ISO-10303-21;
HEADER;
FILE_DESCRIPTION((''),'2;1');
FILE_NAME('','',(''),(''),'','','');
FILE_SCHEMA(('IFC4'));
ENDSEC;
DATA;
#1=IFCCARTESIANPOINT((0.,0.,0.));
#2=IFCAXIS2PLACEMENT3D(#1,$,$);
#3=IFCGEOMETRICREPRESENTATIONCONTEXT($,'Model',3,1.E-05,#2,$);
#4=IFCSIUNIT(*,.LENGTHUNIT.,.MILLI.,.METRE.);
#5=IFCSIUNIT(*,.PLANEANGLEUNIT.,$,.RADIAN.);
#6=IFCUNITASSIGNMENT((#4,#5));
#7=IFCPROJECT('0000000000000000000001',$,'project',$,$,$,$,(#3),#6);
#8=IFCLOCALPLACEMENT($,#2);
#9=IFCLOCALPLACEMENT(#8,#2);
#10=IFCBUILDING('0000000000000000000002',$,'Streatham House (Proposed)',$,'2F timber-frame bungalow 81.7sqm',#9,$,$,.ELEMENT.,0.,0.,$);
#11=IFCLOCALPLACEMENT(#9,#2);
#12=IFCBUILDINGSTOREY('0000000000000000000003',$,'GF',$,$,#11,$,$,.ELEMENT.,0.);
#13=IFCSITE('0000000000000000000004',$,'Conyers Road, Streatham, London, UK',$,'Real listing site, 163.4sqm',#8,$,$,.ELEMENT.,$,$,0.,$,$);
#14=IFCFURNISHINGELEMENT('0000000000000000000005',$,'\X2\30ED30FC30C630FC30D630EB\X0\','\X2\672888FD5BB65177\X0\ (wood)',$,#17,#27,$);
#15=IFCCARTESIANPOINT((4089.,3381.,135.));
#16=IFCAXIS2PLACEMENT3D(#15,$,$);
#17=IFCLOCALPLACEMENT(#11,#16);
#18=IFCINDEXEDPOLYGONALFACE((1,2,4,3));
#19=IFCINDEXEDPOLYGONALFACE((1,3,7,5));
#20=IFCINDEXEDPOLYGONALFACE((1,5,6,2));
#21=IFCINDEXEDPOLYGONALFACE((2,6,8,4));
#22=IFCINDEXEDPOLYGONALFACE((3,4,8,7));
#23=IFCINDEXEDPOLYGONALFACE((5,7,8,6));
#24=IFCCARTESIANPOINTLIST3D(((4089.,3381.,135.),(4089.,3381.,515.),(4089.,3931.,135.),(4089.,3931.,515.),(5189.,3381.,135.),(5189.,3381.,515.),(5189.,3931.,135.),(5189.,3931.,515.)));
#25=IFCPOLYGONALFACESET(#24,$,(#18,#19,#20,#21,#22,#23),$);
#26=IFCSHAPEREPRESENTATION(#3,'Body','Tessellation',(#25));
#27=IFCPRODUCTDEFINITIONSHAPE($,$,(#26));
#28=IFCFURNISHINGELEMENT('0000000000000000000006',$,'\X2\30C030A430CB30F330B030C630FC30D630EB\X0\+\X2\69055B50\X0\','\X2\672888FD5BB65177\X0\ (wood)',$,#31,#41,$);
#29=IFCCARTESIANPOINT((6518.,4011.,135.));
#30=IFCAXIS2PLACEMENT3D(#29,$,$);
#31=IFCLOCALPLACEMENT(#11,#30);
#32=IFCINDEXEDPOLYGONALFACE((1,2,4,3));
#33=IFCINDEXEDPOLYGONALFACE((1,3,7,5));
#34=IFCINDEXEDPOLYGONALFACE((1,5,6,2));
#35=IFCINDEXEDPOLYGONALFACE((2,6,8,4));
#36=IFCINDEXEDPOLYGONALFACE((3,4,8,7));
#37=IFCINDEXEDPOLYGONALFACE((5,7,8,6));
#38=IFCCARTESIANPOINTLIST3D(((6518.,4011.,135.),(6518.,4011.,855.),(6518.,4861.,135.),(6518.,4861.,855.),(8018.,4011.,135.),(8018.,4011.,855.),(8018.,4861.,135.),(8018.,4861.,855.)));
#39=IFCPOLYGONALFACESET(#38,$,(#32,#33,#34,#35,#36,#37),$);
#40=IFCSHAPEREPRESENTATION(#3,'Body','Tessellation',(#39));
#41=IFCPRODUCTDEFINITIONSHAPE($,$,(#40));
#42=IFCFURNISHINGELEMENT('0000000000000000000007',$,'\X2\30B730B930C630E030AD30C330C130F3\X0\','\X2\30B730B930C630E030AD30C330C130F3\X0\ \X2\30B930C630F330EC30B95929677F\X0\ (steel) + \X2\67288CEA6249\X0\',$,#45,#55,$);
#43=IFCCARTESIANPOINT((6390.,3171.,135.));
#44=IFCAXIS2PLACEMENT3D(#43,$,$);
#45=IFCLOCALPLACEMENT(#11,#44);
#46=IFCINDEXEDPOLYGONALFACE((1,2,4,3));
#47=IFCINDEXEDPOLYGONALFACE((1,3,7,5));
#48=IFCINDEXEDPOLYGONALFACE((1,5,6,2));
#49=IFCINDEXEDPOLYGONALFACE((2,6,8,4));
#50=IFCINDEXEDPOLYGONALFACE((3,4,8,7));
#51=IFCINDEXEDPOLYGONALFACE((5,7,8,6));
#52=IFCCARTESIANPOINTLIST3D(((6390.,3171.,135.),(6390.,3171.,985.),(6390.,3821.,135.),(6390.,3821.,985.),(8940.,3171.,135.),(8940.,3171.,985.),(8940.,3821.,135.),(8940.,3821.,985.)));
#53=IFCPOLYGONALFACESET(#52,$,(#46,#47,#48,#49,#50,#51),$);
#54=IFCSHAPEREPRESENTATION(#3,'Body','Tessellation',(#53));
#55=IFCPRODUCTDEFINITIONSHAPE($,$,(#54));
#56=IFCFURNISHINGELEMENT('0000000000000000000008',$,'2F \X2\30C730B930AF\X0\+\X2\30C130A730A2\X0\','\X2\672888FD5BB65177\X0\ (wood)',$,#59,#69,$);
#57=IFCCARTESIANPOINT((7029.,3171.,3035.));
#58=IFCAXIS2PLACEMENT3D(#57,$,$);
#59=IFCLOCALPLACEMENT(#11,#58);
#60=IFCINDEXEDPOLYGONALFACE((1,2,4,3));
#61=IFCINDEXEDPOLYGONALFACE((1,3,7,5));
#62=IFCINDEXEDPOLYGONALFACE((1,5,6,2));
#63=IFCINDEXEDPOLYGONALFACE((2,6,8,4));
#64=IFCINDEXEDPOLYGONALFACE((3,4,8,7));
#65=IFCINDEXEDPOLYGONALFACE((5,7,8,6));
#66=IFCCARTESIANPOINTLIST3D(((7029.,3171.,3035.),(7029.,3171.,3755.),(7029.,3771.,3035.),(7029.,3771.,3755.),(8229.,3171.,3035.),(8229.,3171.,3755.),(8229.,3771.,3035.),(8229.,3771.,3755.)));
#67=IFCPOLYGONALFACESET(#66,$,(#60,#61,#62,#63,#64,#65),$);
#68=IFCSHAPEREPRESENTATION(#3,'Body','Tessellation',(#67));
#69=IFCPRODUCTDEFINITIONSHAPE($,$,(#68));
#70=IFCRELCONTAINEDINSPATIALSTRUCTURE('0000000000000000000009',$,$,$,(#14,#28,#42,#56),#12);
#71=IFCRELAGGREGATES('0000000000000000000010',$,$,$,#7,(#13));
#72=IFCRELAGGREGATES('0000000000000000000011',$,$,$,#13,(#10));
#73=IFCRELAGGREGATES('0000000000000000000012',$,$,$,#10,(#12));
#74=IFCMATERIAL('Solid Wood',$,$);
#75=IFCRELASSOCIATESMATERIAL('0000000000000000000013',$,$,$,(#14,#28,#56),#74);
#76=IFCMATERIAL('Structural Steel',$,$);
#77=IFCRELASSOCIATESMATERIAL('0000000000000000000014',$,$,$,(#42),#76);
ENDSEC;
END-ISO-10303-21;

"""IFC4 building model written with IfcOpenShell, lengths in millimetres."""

from ifc_helpers import new_model, si_unit, frame, frame_2d, origin, place, context, project, spatial, rectangle, extrude, material, element, save


model = new_model("IFC4")

# Units and contexts
model_context = context("Model", 3, precision=1e-05, world=origin())
ifc_project = project(units=[si_unit("LENGTHUNIT", "METRE", prefix="MILLI"), si_unit("PLANEANGLEUNIT", "RADIAN")], contexts=[model_context])

# Site, building, storey
site_placement = place(None, origin())
site = spatial("IfcSite", under=ifc_project, at=site_placement, Name="Conyers Road, Streatham, London, UK", ObjectType="Real listing site, 163.4sqm", CompositionType="ELEMENT", RefElevation=0.0)
building_placement = place(site_placement, origin())
building = spatial("IfcBuilding", under=site, at=building_placement, Name="Streatham House (Proposed)", ObjectType="2F timber-frame bungalow 81.7sqm", CompositionType="ELEMENT", ElevationOfRefHeight=0.0, ElevationOfTerrain=0.0)
storey_placement = place(building_placement, origin())
storey = spatial("IfcBuildingStorey", under=building, at=storey_placement, Name="GF", CompositionType="ELEMENT", Elevation=0.0)

# Shared definitions
ifc_material_1 = material(Name="Solid Wood")

# Shared definitions
ifc_material_2 = material(Name="Structural Steel")

# Furnishing elements
furnishing_1_placement = place(storey_placement, frame((4089.0, 3381.0, 135.0)))
element("IfcFurnishingElement", 1, at=furnishing_1_placement, inside=storey, material=ifc_material_1, Name="ローテーブル", Description="木製家具 (wood)", context=model_context, shape_type="SweptSolid", body=[
    extrude(rectangle(XDim=1100.0, YDim=550.0, at=frame_2d((550.0, 275.0))), frame((4089.0, 3381.0, 135.0)), (0.0, 0.0, 1.0), 380.0),
])
furnishing_2_placement = place(storey_placement, frame((6518.0, 4011.0, 135.0)))
element("IfcFurnishingElement", 2, at=furnishing_2_placement, inside=storey, material=ifc_material_1, Name="ダイニングテーブル+椅子", Description="木製家具 (wood)", context=model_context, shape_type="SweptSolid", body=[
    extrude(rectangle(XDim=1500.0, YDim=850.0, at=frame_2d((750.0, 425.0))), frame((6518.0, 4011.0, 135.0)), (0.0, 0.0, 1.0), 720.0),
])
furnishing_3_placement = place(storey_placement, frame((6390.0, 3171.0, 135.0)))
element("IfcFurnishingElement", 3, at=furnishing_3_placement, inside=storey, material=ifc_material_2, Name="システムキッチン", Description="システムキッチン ステンレス天板 (steel) + 木質扉", context=model_context, shape_type="SweptSolid", body=[
    extrude(rectangle(XDim=2550.0, YDim=650.0, at=frame_2d((1275.0, 325.0))), frame((6390.0, 3171.0, 135.0)), (0.0, 0.0, 1.0), 850.0),
])
furnishing_4_placement = place(storey_placement, frame((7029.0, 3171.0, 3035.0)))
element("IfcFurnishingElement", 4, at=furnishing_4_placement, inside=storey, material=ifc_material_1, Name="2F デスク+チェア", Description="木製家具 (wood)", context=model_context, shape_type="SweptSolid", body=[
    extrude(rectangle(XDim=1200.0, YDim=600.0, at=frame_2d((600.0, 300.0))), frame((7029.0, 3171.0, 3035.0)), (0.0, 0.0, 1.0), 720.0),
])

save(model, "model.ifc")
